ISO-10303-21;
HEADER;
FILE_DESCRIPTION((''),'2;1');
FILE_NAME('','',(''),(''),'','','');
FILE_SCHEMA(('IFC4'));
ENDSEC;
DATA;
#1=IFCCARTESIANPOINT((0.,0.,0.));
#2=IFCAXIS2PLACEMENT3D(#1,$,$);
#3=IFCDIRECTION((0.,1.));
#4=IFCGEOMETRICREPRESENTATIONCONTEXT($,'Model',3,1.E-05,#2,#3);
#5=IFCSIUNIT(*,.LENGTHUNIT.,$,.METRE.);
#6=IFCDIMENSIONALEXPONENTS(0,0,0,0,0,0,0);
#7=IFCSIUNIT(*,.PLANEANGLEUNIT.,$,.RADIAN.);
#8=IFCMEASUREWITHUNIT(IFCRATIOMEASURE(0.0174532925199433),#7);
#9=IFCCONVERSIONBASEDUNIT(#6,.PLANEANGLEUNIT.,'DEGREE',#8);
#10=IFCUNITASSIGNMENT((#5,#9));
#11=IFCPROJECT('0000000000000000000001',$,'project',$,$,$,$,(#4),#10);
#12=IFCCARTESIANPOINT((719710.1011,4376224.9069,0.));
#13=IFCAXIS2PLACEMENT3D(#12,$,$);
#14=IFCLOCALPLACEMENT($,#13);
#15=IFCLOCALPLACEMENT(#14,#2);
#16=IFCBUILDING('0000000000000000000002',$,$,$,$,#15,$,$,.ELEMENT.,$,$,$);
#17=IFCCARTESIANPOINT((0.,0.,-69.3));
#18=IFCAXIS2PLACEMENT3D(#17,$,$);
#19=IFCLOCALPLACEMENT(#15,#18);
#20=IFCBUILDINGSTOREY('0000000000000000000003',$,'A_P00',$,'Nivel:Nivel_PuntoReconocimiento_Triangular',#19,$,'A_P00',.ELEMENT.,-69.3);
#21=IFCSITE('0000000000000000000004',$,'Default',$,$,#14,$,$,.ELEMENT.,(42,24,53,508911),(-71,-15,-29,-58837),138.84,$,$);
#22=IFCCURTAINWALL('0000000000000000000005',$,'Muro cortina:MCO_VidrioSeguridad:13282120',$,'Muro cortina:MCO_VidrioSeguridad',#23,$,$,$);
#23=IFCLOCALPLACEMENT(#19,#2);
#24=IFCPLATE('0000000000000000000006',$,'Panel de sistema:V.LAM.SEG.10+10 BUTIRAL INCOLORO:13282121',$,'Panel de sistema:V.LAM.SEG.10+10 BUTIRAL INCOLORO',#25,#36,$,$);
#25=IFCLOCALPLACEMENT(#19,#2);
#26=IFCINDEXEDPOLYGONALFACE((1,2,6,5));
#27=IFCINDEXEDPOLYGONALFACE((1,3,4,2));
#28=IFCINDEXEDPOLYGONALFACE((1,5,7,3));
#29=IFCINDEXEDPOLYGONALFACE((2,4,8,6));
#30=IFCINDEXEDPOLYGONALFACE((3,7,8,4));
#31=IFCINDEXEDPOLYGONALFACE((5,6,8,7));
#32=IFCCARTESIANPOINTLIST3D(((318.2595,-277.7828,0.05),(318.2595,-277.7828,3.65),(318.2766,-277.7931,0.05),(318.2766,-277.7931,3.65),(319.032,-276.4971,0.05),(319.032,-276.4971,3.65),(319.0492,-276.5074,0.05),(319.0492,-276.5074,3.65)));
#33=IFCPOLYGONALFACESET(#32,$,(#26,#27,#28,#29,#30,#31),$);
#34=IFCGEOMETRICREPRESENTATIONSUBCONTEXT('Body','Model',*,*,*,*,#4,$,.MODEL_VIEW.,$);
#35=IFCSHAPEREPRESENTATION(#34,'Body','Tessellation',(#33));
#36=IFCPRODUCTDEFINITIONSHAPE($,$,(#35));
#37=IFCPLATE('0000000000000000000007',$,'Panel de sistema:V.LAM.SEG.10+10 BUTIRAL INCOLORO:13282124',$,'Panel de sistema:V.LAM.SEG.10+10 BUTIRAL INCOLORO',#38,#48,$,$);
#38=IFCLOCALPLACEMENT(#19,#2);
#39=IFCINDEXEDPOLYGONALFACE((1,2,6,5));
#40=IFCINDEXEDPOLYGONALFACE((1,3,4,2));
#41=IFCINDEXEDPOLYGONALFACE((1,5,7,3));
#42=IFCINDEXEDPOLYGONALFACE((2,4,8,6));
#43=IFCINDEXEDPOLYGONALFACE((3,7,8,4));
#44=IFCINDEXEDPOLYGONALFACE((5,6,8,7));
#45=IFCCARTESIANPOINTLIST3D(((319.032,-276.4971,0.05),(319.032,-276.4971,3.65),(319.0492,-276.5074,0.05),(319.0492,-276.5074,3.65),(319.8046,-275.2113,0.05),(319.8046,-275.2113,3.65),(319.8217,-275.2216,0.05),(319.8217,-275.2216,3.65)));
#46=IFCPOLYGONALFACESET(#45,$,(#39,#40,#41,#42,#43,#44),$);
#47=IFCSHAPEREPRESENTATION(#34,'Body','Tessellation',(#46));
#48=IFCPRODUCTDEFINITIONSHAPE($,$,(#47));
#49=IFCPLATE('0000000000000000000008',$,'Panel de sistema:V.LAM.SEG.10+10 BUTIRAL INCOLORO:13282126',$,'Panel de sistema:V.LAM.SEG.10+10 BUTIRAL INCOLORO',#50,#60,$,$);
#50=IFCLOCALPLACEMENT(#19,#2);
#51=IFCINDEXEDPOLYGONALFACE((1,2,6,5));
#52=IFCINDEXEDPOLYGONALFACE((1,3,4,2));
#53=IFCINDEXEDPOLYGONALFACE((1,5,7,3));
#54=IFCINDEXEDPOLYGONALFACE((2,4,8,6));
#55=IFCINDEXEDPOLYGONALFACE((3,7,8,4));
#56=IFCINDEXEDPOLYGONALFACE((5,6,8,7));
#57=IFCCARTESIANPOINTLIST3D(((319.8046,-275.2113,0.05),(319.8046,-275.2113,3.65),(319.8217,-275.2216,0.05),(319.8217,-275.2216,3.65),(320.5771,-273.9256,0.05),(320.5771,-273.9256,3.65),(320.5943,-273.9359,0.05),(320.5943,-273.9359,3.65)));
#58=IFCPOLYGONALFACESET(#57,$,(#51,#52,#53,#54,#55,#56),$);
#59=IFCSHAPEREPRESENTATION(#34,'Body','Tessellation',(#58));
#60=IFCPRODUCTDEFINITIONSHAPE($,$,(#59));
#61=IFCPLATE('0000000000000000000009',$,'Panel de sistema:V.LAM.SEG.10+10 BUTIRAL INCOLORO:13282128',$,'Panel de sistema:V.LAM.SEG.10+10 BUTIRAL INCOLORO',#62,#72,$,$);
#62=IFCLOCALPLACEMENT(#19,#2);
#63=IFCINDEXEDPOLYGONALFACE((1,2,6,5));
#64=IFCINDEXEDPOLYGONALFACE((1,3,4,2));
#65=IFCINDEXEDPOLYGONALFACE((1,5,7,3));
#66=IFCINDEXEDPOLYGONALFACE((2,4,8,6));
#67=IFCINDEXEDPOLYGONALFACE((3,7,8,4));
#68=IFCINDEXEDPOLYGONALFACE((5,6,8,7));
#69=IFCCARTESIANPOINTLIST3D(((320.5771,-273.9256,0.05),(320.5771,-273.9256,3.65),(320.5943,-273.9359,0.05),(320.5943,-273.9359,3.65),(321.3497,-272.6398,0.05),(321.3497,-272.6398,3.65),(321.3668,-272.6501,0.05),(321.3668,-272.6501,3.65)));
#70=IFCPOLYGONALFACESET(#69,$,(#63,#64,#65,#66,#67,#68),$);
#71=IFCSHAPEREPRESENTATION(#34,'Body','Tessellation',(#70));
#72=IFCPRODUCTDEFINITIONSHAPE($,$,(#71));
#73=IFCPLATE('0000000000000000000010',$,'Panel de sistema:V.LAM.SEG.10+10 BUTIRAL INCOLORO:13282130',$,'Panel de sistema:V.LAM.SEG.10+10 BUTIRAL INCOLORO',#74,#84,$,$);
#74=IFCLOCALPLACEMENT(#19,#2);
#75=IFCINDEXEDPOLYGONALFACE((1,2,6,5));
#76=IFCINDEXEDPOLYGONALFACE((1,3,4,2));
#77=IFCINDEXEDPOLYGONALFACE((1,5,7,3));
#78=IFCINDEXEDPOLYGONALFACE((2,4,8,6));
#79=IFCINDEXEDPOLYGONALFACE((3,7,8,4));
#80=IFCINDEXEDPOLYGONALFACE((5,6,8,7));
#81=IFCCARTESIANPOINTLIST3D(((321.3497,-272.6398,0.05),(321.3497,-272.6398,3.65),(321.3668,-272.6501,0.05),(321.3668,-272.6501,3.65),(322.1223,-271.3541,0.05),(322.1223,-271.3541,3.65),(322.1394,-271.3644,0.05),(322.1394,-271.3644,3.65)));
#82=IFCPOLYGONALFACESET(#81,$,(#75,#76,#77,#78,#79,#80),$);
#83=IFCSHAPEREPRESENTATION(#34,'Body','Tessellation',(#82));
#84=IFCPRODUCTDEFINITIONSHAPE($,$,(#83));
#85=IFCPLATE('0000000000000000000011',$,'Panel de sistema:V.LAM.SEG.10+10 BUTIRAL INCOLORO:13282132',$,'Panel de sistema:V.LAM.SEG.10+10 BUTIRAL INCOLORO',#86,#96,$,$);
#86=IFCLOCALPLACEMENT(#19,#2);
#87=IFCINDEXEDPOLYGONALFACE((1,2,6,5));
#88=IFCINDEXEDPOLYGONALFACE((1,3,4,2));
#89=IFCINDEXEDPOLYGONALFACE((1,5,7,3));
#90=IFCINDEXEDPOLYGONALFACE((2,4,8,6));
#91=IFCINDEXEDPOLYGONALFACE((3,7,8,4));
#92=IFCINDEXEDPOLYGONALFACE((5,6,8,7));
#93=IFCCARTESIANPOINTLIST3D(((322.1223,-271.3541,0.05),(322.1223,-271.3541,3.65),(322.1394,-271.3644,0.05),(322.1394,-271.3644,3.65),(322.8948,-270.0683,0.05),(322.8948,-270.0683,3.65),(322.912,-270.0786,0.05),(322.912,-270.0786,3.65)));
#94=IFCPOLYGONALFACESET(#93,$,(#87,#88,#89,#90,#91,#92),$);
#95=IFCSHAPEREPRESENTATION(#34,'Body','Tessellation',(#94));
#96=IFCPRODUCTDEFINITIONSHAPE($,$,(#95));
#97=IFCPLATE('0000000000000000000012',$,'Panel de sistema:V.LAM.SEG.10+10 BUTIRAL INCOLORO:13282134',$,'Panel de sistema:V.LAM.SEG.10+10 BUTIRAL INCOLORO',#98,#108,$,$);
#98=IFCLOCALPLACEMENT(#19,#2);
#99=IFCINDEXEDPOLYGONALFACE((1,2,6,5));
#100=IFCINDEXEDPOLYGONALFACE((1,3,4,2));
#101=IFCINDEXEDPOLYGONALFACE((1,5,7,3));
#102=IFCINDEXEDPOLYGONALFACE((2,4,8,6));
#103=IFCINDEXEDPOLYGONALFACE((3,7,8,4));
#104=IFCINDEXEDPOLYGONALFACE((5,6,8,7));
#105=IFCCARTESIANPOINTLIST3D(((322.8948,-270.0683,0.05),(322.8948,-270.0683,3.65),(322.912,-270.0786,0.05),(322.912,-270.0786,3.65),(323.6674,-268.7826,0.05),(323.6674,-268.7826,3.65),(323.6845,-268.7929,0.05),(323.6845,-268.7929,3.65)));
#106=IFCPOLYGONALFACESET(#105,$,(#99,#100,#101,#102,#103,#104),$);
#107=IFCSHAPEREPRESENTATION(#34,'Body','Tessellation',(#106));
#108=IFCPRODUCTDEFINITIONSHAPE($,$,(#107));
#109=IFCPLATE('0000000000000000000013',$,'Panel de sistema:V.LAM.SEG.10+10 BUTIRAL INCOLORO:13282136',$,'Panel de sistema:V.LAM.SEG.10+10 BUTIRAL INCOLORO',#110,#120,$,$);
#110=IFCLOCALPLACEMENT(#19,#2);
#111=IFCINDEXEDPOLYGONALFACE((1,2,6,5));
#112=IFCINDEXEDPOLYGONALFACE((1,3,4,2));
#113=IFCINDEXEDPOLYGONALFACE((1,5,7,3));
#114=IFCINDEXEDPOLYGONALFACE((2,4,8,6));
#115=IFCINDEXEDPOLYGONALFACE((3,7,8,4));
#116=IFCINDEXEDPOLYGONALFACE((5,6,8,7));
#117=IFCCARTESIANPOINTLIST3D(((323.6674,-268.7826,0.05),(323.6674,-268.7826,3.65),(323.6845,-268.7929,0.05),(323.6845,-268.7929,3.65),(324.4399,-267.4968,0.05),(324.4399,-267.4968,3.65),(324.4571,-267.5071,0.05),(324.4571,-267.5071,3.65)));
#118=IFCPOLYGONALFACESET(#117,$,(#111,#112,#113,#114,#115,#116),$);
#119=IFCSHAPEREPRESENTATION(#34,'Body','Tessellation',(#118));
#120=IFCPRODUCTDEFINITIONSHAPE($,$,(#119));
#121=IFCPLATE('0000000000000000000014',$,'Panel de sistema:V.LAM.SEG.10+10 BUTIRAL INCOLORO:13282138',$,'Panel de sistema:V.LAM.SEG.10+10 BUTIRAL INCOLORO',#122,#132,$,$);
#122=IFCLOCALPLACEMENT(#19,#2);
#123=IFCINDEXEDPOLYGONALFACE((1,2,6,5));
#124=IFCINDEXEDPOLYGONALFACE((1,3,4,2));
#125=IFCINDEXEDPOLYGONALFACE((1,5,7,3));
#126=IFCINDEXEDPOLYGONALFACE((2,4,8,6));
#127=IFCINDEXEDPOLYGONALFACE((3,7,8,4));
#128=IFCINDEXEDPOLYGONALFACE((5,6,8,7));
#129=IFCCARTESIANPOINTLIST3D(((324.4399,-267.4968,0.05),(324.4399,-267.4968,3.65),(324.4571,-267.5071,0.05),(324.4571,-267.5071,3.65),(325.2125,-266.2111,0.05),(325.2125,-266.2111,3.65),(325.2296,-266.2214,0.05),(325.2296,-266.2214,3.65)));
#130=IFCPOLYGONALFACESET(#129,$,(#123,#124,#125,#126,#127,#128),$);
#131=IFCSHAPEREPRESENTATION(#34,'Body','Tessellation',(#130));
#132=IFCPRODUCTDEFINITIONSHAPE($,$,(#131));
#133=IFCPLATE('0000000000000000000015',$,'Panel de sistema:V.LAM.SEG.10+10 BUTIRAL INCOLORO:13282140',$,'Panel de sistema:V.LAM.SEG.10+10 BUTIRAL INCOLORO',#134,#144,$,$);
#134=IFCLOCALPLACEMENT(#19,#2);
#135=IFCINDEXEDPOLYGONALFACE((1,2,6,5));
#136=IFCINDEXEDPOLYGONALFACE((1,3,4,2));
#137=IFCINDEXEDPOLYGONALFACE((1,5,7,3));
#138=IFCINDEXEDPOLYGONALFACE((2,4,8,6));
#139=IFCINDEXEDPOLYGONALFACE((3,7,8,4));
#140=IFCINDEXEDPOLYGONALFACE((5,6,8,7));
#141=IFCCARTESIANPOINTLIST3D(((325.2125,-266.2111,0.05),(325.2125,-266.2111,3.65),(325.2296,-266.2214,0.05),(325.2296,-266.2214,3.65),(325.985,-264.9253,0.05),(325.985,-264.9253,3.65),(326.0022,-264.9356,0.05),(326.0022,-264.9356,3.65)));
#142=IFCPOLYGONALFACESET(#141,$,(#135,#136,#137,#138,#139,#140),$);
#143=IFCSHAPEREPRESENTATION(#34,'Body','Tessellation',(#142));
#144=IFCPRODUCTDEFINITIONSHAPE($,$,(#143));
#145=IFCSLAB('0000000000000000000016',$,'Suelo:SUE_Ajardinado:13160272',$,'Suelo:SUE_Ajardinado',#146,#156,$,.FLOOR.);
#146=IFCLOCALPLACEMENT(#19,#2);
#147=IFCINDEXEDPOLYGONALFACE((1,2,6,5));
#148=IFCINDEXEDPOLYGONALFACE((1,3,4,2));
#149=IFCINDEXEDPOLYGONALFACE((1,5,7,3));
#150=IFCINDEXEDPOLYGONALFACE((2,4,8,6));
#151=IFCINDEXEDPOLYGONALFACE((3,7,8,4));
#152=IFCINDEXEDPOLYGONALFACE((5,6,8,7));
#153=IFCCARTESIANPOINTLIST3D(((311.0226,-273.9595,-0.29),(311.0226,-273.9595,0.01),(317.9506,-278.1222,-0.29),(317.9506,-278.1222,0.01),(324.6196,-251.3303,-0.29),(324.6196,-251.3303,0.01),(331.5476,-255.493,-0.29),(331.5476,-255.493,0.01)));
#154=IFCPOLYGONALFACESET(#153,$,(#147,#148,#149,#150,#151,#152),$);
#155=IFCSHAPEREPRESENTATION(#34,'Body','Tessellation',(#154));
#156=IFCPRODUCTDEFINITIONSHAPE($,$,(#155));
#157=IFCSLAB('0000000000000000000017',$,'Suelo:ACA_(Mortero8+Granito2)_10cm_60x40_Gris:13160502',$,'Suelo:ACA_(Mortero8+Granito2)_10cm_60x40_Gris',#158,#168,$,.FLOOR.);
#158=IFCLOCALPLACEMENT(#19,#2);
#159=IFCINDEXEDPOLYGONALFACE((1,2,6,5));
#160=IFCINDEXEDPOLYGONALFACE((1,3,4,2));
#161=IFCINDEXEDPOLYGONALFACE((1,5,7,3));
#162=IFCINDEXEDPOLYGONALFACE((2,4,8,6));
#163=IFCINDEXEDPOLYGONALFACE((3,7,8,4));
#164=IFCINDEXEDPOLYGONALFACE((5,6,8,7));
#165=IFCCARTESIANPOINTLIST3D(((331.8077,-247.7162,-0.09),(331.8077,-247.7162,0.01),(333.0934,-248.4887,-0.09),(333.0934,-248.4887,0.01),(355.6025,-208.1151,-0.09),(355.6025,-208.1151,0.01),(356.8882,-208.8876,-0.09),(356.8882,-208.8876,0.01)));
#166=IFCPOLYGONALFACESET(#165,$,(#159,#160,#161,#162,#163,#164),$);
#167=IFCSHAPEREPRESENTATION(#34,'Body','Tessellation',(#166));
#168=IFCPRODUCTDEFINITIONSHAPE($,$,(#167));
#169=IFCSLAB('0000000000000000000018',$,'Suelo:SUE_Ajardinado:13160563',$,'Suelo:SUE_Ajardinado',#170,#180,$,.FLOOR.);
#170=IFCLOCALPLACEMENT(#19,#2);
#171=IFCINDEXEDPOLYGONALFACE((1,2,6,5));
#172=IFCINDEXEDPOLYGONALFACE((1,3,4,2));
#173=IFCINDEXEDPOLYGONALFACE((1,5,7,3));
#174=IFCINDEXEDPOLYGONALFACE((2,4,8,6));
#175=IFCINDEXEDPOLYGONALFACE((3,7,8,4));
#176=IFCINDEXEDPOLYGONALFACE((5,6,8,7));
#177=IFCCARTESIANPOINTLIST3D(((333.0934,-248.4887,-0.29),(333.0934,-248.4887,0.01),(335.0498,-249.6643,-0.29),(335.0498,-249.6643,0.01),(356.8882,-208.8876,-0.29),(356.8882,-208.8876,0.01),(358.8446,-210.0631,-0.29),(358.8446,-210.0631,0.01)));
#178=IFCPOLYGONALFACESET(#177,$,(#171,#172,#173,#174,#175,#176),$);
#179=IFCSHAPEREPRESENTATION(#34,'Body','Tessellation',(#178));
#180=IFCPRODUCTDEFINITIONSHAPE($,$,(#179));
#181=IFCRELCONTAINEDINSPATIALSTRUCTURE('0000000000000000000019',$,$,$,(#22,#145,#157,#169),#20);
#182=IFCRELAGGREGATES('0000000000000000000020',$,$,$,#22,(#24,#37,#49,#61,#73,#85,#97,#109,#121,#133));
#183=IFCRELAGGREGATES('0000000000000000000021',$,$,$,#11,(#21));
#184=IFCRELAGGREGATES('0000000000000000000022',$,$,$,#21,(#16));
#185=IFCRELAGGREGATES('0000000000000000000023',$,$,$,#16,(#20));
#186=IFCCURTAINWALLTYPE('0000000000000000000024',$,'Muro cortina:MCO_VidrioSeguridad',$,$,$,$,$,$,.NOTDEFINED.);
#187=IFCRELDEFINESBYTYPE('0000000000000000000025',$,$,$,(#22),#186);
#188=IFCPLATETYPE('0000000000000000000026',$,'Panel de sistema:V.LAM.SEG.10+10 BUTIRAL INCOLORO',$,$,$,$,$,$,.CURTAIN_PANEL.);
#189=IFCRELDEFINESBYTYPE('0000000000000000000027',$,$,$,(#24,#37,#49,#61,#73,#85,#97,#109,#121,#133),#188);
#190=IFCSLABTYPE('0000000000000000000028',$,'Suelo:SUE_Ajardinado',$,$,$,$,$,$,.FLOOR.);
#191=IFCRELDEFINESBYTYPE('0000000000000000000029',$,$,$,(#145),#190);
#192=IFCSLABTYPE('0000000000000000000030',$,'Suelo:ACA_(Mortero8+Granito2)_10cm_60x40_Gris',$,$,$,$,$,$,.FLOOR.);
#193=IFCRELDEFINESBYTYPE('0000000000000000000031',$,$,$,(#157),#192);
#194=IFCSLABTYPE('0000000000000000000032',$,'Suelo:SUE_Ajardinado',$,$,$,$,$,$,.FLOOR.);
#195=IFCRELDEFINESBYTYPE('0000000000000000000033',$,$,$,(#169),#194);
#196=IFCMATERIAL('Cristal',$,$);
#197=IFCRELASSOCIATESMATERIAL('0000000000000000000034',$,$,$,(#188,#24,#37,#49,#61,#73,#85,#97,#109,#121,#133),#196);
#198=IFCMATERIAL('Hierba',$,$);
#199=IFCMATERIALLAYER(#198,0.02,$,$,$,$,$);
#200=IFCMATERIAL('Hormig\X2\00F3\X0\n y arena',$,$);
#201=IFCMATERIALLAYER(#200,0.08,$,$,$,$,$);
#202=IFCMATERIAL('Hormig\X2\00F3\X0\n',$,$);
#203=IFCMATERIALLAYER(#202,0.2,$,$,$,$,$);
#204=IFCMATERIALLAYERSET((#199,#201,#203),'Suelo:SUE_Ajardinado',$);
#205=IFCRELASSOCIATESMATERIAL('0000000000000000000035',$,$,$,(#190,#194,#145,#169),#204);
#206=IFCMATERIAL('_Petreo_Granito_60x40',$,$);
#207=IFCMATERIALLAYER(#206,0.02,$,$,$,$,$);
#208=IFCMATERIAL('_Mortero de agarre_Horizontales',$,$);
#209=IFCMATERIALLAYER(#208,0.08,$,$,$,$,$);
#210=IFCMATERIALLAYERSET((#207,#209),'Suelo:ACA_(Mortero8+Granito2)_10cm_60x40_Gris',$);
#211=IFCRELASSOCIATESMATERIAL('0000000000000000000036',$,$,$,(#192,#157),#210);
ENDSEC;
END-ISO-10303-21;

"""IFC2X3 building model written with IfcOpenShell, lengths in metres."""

from ifc_helpers import new_model, entity, si_unit, converted_unit, direction, frame, frame_2d, origin, place, context, subcontext, project, spatial, rectangle, extrude, source, transform, mapped, material, layer, layer_set, layer_usage, type_object, type_shapes, element, aggregate, save


model = new_model("IFC2X3")

# Units and contexts
model_context = context("Model", 3, precision=1e-05, world=origin(), true_north=direction((0.0, 1.0)))
body_context = subcontext(model_context, "Body", "Model", "MODEL_VIEW")
ifc_project = project(units=[si_unit("LENGTHUNIT", "METRE"), converted_unit("PLANEANGLEUNIT", "DEGREE", entity("IfcRatioMeasure", 0.0174532925199433), si_unit("PLANEANGLEUNIT", "RADIAN"), dimensions=[0, 0, 0, 0, 0, 0, 0])], contexts=[model_context])

# Site, building, storey
site_placement = place(None, frame((719710.1011, 4376224.9069, 0.0)))
site = spatial("IfcSite", under=ifc_project, at=site_placement, Name="Default", CompositionType="ELEMENT", RefLatitude=(42, 24, 53, 508911), RefLongitude=(-71, -15, -29, -58837), RefElevation=138.84)
building_placement = place(site_placement, origin())
building = spatial("IfcBuilding", under=site, at=building_placement, CompositionType="ELEMENT")
storey_placement = place(building_placement, frame((0.0, 0.0, -69.3)))
storey = spatial("IfcBuildingStorey", under=building, at=storey_placement, Name="A_P00", ObjectType="Nivel:Nivel_PuntoReconocimiento_Triangular", LongName="A_P00", CompositionType="ELEMENT", Elevation=-69.3)

# Curtain wall, plates
curtain_wall_type = type_object("IfcCurtainWallType", Name="Muro cortina:MCO_VidrioSeguridad", PredefinedType="NOTDEFINED")
curtain_wall_placement = place(storey_placement, frame((0.0, 0.0, 69.3)))
curtain_wall = element("IfcCurtainWall", 1, at=curtain_wall_placement, inside=storey, type_object=curtain_wall_type, Name="Muro cortina:MCO_VidrioSeguridad:13282120", ObjectType="Muro cortina:MCO_VidrioSeguridad")
ifc_material_1 = material(Name="Cristal")
plate_type_1 = type_object("IfcPlateType", Name="Panel de sistema:V.LAM.SEG.10+10 BUTIRAL INCOLORO", PredefinedType="CURTAIN_PANEL", material=ifc_material_1)
shared_shape_1 = source(origin(), body_context, "Body", "SweptSolid", [
    extrude(rectangle(XDim=0.02, YDim=1.5, at=frame_2d((0.0, 0.0), x_axis=(1.0, 0.0))), frame((0.0, 0.0, 0.0), z_axis=(0.0, 0.0, 1.0), x_axis=(0.0, 1.0, 0.0)), (0.0, 0.0, 1.0), 3.6),
])
type_shapes(plate_type_1, [shared_shape_1])
plate_1_placement = place(curtain_wall_placement, frame((318.6543, -277.1451, -69.25), z_axis=(0.0, 0.0, 1.0), x_axis=(0.515038, 0.857167, 0.0)))
plate_1 = element("IfcPlate", 2, at=plate_1_placement, type_object=plate_type_1, material=ifc_material_1, Name="Panel de sistema:V.LAM.SEG.10+10 BUTIRAL INCOLORO:13282121", ObjectType="Panel de sistema:V.LAM.SEG.10+10 BUTIRAL INCOLORO", context=body_context, shape_type="MappedRepresentation", body=[
    mapped(shared_shape_1, transform((0.0, 0.0, 0.0), scale=1.0)),
])
plate_2_placement = place(curtain_wall_placement, frame((319.4269, -275.8594, -69.25), z_axis=(0.0, 0.0, 1.0), x_axis=(0.515038, 0.857167, 0.0)))
plate_2 = element("IfcPlate", 3, at=plate_2_placement, type_object=plate_type_1, material=ifc_material_1, Name="Panel de sistema:V.LAM.SEG.10+10 BUTIRAL INCOLORO:13282124", ObjectType="Panel de sistema:V.LAM.SEG.10+10 BUTIRAL INCOLORO", context=body_context, shape_type="MappedRepresentation", body=[
    mapped(shared_shape_1, transform((0.0, 0.0, 0.0), scale=1.0)),
])
plate_3_placement = place(curtain_wall_placement, frame((320.1994, -274.5736, -69.25), z_axis=(0.0, 0.0, 1.0), x_axis=(0.515038, 0.857167, 0.0)))
plate_3 = element("IfcPlate", 4, at=plate_3_placement, type_object=plate_type_1, material=ifc_material_1, Name="Panel de sistema:V.LAM.SEG.10+10 BUTIRAL INCOLORO:13282126", ObjectType="Panel de sistema:V.LAM.SEG.10+10 BUTIRAL INCOLORO", context=body_context, shape_type="MappedRepresentation", body=[
    mapped(shared_shape_1, transform((0.0, 0.0, 0.0), scale=1.0)),
])
plate_4_placement = place(curtain_wall_placement, frame((320.972, -273.2879, -69.25), z_axis=(0.0, 0.0, 1.0), x_axis=(0.515038, 0.857167, 0.0)))
plate_4 = element("IfcPlate", 5, at=plate_4_placement, type_object=plate_type_1, material=ifc_material_1, Name="Panel de sistema:V.LAM.SEG.10+10 BUTIRAL INCOLORO:13282128", ObjectType="Panel de sistema:V.LAM.SEG.10+10 BUTIRAL INCOLORO", context=body_context, shape_type="MappedRepresentation", body=[
    mapped(shared_shape_1, transform((0.0, 0.0, 0.0), scale=1.0)),
])
plate_5_placement = place(curtain_wall_placement, frame((321.7446, -272.0021, -69.25), z_axis=(0.0, 0.0, 1.0), x_axis=(0.515038, 0.857167, 0.0)))
plate_5 = element("IfcPlate", 6, at=plate_5_placement, type_object=plate_type_1, material=ifc_material_1, Name="Panel de sistema:V.LAM.SEG.10+10 BUTIRAL INCOLORO:13282130", ObjectType="Panel de sistema:V.LAM.SEG.10+10 BUTIRAL INCOLORO", context=body_context, shape_type="MappedRepresentation", body=[
    mapped(shared_shape_1, transform((0.0, 0.0, 0.0), scale=1.0)),
])
plate_6_placement = place(curtain_wall_placement, frame((322.5171, -270.7164, -69.25), z_axis=(0.0, 0.0, 1.0), x_axis=(0.515038, 0.857167, 0.0)))
plate_6 = element("IfcPlate", 7, at=plate_6_placement, type_object=plate_type_1, material=ifc_material_1, Name="Panel de sistema:V.LAM.SEG.10+10 BUTIRAL INCOLORO:13282132", ObjectType="Panel de sistema:V.LAM.SEG.10+10 BUTIRAL INCOLORO", context=body_context, shape_type="MappedRepresentation", body=[
    mapped(shared_shape_1, transform((0.0, 0.0, 0.0), scale=1.0)),
])
plate_7_placement = place(curtain_wall_placement, frame((323.2897, -269.4306, -69.25), z_axis=(0.0, 0.0, 1.0), x_axis=(0.515038, 0.857167, 0.0)))
plate_7 = element("IfcPlate", 8, at=plate_7_placement, type_object=plate_type_1, material=ifc_material_1, Name="Panel de sistema:V.LAM.SEG.10+10 BUTIRAL INCOLORO:13282134", ObjectType="Panel de sistema:V.LAM.SEG.10+10 BUTIRAL INCOLORO", context=body_context, shape_type="MappedRepresentation", body=[
    mapped(shared_shape_1, transform((0.0, 0.0, 0.0), scale=1.0)),
])
plate_8_placement = place(curtain_wall_placement, frame((324.0622, -268.1449, -69.25), z_axis=(0.0, 0.0, 1.0), x_axis=(0.515038, 0.857167, 0.0)))
plate_8 = element("IfcPlate", 9, at=plate_8_placement, type_object=plate_type_1, material=ifc_material_1, Name="Panel de sistema:V.LAM.SEG.10+10 BUTIRAL INCOLORO:13282136", ObjectType="Panel de sistema:V.LAM.SEG.10+10 BUTIRAL INCOLORO", context=body_context, shape_type="MappedRepresentation", body=[
    mapped(shared_shape_1, transform((0.0, 0.0, 0.0), scale=1.0)),
])
plate_9_placement = place(curtain_wall_placement, frame((324.8348, -266.8591, -69.25), z_axis=(0.0, 0.0, 1.0), x_axis=(0.515038, 0.857167, 0.0)))
plate_9 = element("IfcPlate", 10, at=plate_9_placement, type_object=plate_type_1, material=ifc_material_1, Name="Panel de sistema:V.LAM.SEG.10+10 BUTIRAL INCOLORO:13282138", ObjectType="Panel de sistema:V.LAM.SEG.10+10 BUTIRAL INCOLORO", context=body_context, shape_type="MappedRepresentation", body=[
    mapped(shared_shape_1, transform((0.0, 0.0, 0.0), scale=1.0)),
])
plate_10_placement = place(curtain_wall_placement, frame((325.6073, -265.5734, -69.25), z_axis=(0.0, 0.0, 1.0), x_axis=(0.515038, 0.857167, 0.0)))
plate_10 = element("IfcPlate", 11, at=plate_10_placement, type_object=plate_type_1, material=ifc_material_1, Name="Panel de sistema:V.LAM.SEG.10+10 BUTIRAL INCOLORO:13282140", ObjectType="Panel de sistema:V.LAM.SEG.10+10 BUTIRAL INCOLORO", context=body_context, shape_type="MappedRepresentation", body=[
    mapped(shared_shape_1, transform((0.0, 0.0, 0.0), scale=1.0)),
])

# Slabs
ifc_material_2 = material(Name="Hierba")
ifc_layer_1 = layer(ifc_material_2, 0.02)
ifc_material_3 = material(Name="Hormigón y arena")
ifc_layer_2 = layer(ifc_material_3, 0.08)
ifc_material_4 = material(Name="Hormigón")
ifc_layer_3 = layer(ifc_material_4, 0.2)
ifc_layer_set_1 = layer_set([ifc_layer_1, ifc_layer_2, ifc_layer_3], Name="Suelo:SUE_Ajardinado")
ifc_layer_usage_1 = layer_usage(ifc_layer_set_1, "AXIS3", "POSITIVE", 0.0)
slab_type_1 = type_object("IfcSlabType", Name="Suelo:SUE_Ajardinado", PredefinedType="FLOOR", material=ifc_layer_set_1)
slab_1_placement = place(storey_placement, origin())
element("IfcSlab", 12, at=slab_1_placement, inside=storey, type_object=slab_type_1, material=ifc_layer_usage_1, Name="Suelo:SUE_Ajardinado:13160272", ObjectType="Suelo:SUE_Ajardinado", PredefinedType="FLOOR", context=body_context, shape_type="SweptSolid", body=[
    extrude(rectangle(XDim=26.4, YDim=8.0824, at=frame_2d((0.0, 0.0), x_axis=(1.0, 0.0))), frame((321.2851, -264.7262, 0.01), z_axis=(0.0, 0.0, -1.0), x_axis=(-0.515038, -0.857167, 0.0)), (0.0, 0.0, 1.0), 0.3),
])
ifc_material_5 = material(Name="_Petreo_Granito_60x40")
ifc_layer_4 = layer(ifc_material_5, 0.02)
ifc_material_6 = material(Name="_Mortero de agarre_Horizontales")
ifc_layer_5 = layer(ifc_material_6, 0.08)
ifc_layer_set_2 = layer_set([ifc_layer_4, ifc_layer_5], Name="Suelo:ACA_(Mortero8+Granito2)_10cm_60x40_Gris")
ifc_layer_usage_2 = layer_usage(ifc_layer_set_2, "AXIS3", "POSITIVE", 0.0)
slab_type_2 = type_object("IfcSlabType", Name="Suelo:ACA_(Mortero8+Granito2)_10cm_60x40_Gris", PredefinedType="FLOOR", material=ifc_layer_set_2)
slab_2_placement = place(storey_placement, origin())
element("IfcSlab", 13, at=slab_2_placement, inside=storey, type_object=slab_type_2, material=ifc_layer_usage_2, Name="Suelo:ACA_(Mortero8+Granito2)_10cm_60x40_Gris:13160502", ObjectType="Suelo:ACA_(Mortero8+Granito2)_10cm_60x40_Gris", PredefinedType="FLOOR", context=body_context, shape_type="SweptSolid", body=[
    extrude(rectangle(XDim=46.2, YDim=1.5, at=frame_2d((0.0, 0.0), x_axis=(1.0, 0.0))), frame((344.3479, -228.3019, 0.01), z_axis=(0.0, 0.0, -1.0), x_axis=(-0.515038, -0.857167, 0.0)), (0.0, 0.0, 1.0), 0.1),
])
ifc_layer_usage_3 = layer_usage(ifc_layer_set_1, "AXIS3", "POSITIVE", 0.0)
slab_type_3 = type_object("IfcSlabType", Name="Suelo:SUE_Ajardinado", PredefinedType="FLOOR", material=ifc_layer_set_1)
slab_3_placement = place(storey_placement, origin())
element("IfcSlab", 14, at=slab_3_placement, inside=storey, type_object=slab_type_3, material=ifc_layer_usage_3, Name="Suelo:SUE_Ajardinado:13160563", ObjectType="Suelo:SUE_Ajardinado", PredefinedType="FLOOR", context=body_context, shape_type="SweptSolid", body=[
    extrude(rectangle(XDim=46.2, YDim=2.2824, at=frame_2d((0.0, 0.0), x_axis=(1.0, 0.0))), frame((345.969, -229.2759, 0.01), z_axis=(0.0, 0.0, -1.0), x_axis=(-0.515038, -0.857167, 0.0)), (0.0, 0.0, 1.0), 0.3),
])

aggregate(curtain_wall, [plate_1, plate_2, plate_3, plate_4, plate_5, plate_6, plate_7, plate_8, plate_9, plate_10])

save(model, "model.ifc")
